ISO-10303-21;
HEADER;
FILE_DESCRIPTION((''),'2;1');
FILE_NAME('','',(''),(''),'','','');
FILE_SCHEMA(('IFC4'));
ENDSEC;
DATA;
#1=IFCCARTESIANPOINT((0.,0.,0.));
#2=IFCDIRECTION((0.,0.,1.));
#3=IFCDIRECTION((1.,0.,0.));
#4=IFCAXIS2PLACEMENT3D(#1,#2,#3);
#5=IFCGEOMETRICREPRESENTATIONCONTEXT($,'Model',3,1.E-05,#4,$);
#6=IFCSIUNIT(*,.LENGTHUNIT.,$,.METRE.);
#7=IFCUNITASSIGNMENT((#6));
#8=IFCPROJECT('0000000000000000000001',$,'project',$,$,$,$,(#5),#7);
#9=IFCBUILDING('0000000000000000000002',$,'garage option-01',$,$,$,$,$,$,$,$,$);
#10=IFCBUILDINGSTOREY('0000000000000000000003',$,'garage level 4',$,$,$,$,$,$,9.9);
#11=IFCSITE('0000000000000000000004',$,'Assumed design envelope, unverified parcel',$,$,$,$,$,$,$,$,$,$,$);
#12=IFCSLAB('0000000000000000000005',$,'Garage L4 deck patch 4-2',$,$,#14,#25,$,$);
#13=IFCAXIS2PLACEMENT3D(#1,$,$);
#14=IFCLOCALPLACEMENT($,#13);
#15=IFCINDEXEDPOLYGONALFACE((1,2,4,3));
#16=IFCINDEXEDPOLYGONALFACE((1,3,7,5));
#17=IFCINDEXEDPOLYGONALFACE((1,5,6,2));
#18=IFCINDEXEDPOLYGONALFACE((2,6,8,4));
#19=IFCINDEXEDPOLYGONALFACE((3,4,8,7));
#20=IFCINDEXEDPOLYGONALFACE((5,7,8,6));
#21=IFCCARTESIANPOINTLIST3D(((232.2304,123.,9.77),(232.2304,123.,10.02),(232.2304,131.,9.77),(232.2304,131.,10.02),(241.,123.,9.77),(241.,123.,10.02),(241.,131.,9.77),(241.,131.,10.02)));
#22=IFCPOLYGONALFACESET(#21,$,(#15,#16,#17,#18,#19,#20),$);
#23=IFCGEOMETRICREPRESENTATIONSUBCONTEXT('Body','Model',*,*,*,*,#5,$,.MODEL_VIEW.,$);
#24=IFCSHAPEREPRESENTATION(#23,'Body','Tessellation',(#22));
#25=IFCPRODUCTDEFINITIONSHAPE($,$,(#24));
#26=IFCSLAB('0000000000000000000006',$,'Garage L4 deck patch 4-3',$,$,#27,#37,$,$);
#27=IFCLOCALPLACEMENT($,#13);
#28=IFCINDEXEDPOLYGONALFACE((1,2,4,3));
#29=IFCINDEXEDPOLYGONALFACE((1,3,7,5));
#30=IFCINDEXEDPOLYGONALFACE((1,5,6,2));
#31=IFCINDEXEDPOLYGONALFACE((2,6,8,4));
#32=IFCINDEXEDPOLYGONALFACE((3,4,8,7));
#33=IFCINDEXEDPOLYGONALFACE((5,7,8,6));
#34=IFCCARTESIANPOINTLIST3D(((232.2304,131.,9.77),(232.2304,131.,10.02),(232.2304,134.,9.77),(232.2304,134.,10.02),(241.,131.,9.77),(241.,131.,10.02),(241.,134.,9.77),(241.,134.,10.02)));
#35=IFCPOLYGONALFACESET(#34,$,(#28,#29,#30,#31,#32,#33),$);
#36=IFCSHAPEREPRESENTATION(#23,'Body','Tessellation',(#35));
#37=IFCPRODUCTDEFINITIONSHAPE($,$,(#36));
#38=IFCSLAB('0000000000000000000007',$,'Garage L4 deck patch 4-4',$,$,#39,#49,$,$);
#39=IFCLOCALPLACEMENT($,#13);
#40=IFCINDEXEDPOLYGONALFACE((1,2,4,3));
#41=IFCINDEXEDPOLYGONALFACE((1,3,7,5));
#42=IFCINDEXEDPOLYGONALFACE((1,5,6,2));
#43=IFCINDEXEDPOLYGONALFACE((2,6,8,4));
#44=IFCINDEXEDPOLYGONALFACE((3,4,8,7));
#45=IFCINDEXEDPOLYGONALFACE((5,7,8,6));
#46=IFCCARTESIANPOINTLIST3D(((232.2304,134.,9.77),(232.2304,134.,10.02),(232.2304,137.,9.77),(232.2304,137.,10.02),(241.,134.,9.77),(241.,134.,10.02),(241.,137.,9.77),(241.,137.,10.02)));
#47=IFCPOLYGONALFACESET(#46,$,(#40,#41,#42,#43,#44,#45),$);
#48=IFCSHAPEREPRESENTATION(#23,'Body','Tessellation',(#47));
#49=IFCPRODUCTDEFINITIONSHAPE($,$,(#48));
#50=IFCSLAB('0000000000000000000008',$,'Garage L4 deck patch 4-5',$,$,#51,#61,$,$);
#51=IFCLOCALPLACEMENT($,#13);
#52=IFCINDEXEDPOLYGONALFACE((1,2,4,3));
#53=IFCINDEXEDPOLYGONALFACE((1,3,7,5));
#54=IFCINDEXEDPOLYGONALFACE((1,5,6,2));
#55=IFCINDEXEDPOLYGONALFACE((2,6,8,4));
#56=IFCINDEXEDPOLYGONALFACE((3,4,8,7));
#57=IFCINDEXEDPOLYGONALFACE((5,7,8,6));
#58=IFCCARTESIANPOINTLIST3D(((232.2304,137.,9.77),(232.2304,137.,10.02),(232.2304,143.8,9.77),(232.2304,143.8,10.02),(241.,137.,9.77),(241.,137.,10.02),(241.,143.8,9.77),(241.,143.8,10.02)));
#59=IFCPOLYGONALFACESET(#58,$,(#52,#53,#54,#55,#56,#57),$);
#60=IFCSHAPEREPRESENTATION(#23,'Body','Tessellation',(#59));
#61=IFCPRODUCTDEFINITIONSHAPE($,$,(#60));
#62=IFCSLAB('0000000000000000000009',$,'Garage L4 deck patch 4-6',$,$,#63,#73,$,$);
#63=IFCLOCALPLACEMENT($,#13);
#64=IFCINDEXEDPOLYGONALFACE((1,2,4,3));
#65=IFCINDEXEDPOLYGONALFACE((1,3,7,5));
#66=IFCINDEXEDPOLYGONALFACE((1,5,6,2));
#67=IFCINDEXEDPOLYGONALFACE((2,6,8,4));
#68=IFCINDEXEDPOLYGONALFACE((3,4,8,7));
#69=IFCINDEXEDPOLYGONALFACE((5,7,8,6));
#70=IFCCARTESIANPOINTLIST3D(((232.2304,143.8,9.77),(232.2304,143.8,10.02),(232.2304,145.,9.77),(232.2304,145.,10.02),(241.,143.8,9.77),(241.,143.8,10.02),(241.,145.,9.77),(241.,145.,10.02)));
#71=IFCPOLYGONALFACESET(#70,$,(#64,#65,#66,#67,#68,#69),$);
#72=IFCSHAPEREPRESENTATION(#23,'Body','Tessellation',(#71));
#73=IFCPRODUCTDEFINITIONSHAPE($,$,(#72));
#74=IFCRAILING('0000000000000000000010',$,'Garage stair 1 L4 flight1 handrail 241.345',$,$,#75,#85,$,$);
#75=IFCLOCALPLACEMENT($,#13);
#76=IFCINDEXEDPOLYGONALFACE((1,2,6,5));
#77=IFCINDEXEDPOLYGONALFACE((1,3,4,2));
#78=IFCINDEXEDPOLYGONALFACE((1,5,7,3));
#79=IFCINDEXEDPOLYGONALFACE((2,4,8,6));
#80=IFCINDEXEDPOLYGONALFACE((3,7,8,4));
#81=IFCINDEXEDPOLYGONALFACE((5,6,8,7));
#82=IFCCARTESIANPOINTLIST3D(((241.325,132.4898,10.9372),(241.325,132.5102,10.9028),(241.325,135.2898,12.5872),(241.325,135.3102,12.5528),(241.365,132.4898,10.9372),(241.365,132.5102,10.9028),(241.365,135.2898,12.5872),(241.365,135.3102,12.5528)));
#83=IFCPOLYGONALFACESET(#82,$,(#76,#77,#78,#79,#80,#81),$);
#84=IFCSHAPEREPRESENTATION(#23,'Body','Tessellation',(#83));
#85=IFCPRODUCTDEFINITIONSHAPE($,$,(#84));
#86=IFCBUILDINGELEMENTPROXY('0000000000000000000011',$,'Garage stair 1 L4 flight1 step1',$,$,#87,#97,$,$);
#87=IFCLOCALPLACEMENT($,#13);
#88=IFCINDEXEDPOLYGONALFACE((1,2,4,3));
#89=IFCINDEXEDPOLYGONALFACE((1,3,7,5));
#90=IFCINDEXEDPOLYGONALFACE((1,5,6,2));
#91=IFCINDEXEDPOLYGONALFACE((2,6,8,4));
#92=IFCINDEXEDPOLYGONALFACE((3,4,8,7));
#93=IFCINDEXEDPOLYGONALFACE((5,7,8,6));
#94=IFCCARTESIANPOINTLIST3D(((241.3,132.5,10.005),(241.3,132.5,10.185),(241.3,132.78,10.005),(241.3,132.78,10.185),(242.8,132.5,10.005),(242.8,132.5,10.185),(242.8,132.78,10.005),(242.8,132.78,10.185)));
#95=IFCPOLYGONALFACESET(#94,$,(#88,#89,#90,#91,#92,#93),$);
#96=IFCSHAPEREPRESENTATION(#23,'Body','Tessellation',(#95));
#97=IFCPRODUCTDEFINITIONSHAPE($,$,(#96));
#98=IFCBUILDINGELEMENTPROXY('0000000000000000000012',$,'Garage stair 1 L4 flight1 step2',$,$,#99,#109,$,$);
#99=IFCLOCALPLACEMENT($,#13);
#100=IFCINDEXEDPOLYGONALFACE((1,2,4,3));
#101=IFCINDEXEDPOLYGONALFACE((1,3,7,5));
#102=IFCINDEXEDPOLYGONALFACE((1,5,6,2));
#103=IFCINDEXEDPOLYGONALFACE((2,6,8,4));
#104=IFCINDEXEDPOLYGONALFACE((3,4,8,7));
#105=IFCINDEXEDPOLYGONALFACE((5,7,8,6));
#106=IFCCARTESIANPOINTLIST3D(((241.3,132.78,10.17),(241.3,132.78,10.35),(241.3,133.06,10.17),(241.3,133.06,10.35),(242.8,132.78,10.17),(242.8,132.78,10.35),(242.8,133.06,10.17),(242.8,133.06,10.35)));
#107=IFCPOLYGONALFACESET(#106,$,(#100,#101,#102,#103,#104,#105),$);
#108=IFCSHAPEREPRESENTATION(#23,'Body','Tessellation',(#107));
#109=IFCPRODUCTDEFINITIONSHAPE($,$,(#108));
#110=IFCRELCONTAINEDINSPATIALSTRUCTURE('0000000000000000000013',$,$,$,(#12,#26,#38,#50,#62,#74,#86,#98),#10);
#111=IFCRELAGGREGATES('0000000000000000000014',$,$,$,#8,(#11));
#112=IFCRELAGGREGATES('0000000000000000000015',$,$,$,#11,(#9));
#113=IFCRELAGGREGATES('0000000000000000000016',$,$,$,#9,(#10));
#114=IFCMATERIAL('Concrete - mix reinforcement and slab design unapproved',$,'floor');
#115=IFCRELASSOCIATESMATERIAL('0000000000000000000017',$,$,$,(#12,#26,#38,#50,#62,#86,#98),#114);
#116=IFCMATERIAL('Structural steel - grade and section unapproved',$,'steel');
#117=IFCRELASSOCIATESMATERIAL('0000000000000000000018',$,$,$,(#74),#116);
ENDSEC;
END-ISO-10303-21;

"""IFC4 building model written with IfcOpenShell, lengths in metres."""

from ifc_helpers import new_model, si_unit, frame, origin_with_axes, place, context, subcontext, project, spatial, rectangle, extrude, material, element, save


model = new_model("IFC4")

# Units and contexts
model_context = context("Model", 3, precision=1e-05, world=origin_with_axes())
body_context = subcontext(model_context, "Body", "Model", "MODEL_VIEW")
ifc_project = project(units=[si_unit("LENGTHUNIT", "METRE")], contexts=[model_context])

# Site, building, storey
site = spatial("IfcSite", under=ifc_project, Name="Assumed design envelope, unverified parcel")
building = spatial("IfcBuilding", under=site, Name="garage option-01")
storey = spatial("IfcBuildingStorey", under=building, Name="garage level 4", Elevation=9.9)

# Slabs
ifc_material_1 = material(Name="Concrete - mix reinforcement and slab design unapproved", Category="floor")
slab_1_placement = place(None, frame((236.6152, 127.0, 9.77), z_axis=(0.0, 0.0, 1.0), x_axis=(1.0, 0.0, 0.0)))
element("IfcSlab", 1, at=slab_1_placement, inside=storey, material=ifc_material_1, Name="Garage L4 deck patch 4-2", context=body_context, shape_type="SweptSolid", body=[
    extrude(rectangle(XDim=8.7696, YDim=8.0), origin_with_axes(), (0.0, 0.0, 1.0), 0.25),
])
for number, where, z_axis, x_axis, name in (
    (2, (236.6152, 132.5, 9.77), (0.0, 0.0, 1.0), (1.0, 0.0, 0.0), "Garage L4 deck patch 4-3"),
    (3, (236.6152, 135.5, 9.77), (0.0, 0.0, 1.0), (1.0, 0.0, 0.0), "Garage L4 deck patch 4-4"),
):
    element("IfcSlab", number, at=place(None, frame(where, z_axis=z_axis, x_axis=x_axis)), inside=storey, material=ifc_material_1, Name=name, context=body_context, shape_type="SweptSolid", body=[
        extrude(rectangle(XDim=8.7696, YDim=3.0), origin_with_axes(), (0.0, 0.0, 1.0), 0.25),
    ])
slab_2_placement = place(None, frame((236.6152, 140.4, 9.77), z_axis=(0.0, 0.0, 1.0), x_axis=(1.0, 0.0, 0.0)))
element("IfcSlab", 4, at=slab_2_placement, inside=storey, material=ifc_material_1, Name="Garage L4 deck patch 4-5", context=body_context, shape_type="SweptSolid", body=[
    extrude(rectangle(XDim=8.7696, YDim=6.8), origin_with_axes(), (0.0, 0.0, 1.0), 0.25),
])
slab_3_placement = place(None, frame((236.6152, 144.4, 9.77), z_axis=(0.0, 0.0, 1.0), x_axis=(1.0, 0.0, 0.0)))
element("IfcSlab", 5, at=slab_3_placement, inside=storey, material=ifc_material_1, Name="Garage L4 deck patch 4-6", context=body_context, shape_type="SweptSolid", body=[
    extrude(rectangle(XDim=8.7696, YDim=1.2), origin_with_axes(), (0.0, 0.0, 1.0), 0.25),
])

# Railing
ifc_material_2 = material(Name="Structural steel - grade and section unapproved", Category="steel")
railing_placement = place(None, frame((241.345, 132.5, 10.92), z_axis=(0.0, 0.861539, 0.507692), x_axis=(-1.0, 0.0, 0.0)))
element("IfcRailing", 6, at=railing_placement, inside=storey, material=ifc_material_2, Name="Garage stair 1 L4 flight1 handrail 241.345", context=body_context, shape_type="SweptSolid", body=[
    extrude(rectangle(XDim=0.04, YDim=0.04), origin_with_axes(), (0.0, 0.0, 1.0), 3.25),
])

# Building element proxies
for number, where, z_axis, x_axis, name in (
    (7, (242.05, 132.64, 10.005), (0.0, 0.0, 1.0), (1.0, 0.0, 0.0), "Garage stair 1 L4 flight1 step1"),
    (8, (242.05, 132.92, 10.17), (0.0, 0.0, 1.0), (1.0, 0.0, 0.0), "Garage stair 1 L4 flight1 step2"),
):
    element("IfcBuildingElementProxy", number, at=place(None, frame(where, z_axis=z_axis, x_axis=x_axis)), inside=storey, material=ifc_material_1, Name=name, context=body_context, shape_type="SweptSolid", body=[
        extrude(rectangle(XDim=1.5, YDim=0.28), origin_with_axes(), (0.0, 0.0, 1.0), 0.18),
    ])

save(model, "model.ifc")
